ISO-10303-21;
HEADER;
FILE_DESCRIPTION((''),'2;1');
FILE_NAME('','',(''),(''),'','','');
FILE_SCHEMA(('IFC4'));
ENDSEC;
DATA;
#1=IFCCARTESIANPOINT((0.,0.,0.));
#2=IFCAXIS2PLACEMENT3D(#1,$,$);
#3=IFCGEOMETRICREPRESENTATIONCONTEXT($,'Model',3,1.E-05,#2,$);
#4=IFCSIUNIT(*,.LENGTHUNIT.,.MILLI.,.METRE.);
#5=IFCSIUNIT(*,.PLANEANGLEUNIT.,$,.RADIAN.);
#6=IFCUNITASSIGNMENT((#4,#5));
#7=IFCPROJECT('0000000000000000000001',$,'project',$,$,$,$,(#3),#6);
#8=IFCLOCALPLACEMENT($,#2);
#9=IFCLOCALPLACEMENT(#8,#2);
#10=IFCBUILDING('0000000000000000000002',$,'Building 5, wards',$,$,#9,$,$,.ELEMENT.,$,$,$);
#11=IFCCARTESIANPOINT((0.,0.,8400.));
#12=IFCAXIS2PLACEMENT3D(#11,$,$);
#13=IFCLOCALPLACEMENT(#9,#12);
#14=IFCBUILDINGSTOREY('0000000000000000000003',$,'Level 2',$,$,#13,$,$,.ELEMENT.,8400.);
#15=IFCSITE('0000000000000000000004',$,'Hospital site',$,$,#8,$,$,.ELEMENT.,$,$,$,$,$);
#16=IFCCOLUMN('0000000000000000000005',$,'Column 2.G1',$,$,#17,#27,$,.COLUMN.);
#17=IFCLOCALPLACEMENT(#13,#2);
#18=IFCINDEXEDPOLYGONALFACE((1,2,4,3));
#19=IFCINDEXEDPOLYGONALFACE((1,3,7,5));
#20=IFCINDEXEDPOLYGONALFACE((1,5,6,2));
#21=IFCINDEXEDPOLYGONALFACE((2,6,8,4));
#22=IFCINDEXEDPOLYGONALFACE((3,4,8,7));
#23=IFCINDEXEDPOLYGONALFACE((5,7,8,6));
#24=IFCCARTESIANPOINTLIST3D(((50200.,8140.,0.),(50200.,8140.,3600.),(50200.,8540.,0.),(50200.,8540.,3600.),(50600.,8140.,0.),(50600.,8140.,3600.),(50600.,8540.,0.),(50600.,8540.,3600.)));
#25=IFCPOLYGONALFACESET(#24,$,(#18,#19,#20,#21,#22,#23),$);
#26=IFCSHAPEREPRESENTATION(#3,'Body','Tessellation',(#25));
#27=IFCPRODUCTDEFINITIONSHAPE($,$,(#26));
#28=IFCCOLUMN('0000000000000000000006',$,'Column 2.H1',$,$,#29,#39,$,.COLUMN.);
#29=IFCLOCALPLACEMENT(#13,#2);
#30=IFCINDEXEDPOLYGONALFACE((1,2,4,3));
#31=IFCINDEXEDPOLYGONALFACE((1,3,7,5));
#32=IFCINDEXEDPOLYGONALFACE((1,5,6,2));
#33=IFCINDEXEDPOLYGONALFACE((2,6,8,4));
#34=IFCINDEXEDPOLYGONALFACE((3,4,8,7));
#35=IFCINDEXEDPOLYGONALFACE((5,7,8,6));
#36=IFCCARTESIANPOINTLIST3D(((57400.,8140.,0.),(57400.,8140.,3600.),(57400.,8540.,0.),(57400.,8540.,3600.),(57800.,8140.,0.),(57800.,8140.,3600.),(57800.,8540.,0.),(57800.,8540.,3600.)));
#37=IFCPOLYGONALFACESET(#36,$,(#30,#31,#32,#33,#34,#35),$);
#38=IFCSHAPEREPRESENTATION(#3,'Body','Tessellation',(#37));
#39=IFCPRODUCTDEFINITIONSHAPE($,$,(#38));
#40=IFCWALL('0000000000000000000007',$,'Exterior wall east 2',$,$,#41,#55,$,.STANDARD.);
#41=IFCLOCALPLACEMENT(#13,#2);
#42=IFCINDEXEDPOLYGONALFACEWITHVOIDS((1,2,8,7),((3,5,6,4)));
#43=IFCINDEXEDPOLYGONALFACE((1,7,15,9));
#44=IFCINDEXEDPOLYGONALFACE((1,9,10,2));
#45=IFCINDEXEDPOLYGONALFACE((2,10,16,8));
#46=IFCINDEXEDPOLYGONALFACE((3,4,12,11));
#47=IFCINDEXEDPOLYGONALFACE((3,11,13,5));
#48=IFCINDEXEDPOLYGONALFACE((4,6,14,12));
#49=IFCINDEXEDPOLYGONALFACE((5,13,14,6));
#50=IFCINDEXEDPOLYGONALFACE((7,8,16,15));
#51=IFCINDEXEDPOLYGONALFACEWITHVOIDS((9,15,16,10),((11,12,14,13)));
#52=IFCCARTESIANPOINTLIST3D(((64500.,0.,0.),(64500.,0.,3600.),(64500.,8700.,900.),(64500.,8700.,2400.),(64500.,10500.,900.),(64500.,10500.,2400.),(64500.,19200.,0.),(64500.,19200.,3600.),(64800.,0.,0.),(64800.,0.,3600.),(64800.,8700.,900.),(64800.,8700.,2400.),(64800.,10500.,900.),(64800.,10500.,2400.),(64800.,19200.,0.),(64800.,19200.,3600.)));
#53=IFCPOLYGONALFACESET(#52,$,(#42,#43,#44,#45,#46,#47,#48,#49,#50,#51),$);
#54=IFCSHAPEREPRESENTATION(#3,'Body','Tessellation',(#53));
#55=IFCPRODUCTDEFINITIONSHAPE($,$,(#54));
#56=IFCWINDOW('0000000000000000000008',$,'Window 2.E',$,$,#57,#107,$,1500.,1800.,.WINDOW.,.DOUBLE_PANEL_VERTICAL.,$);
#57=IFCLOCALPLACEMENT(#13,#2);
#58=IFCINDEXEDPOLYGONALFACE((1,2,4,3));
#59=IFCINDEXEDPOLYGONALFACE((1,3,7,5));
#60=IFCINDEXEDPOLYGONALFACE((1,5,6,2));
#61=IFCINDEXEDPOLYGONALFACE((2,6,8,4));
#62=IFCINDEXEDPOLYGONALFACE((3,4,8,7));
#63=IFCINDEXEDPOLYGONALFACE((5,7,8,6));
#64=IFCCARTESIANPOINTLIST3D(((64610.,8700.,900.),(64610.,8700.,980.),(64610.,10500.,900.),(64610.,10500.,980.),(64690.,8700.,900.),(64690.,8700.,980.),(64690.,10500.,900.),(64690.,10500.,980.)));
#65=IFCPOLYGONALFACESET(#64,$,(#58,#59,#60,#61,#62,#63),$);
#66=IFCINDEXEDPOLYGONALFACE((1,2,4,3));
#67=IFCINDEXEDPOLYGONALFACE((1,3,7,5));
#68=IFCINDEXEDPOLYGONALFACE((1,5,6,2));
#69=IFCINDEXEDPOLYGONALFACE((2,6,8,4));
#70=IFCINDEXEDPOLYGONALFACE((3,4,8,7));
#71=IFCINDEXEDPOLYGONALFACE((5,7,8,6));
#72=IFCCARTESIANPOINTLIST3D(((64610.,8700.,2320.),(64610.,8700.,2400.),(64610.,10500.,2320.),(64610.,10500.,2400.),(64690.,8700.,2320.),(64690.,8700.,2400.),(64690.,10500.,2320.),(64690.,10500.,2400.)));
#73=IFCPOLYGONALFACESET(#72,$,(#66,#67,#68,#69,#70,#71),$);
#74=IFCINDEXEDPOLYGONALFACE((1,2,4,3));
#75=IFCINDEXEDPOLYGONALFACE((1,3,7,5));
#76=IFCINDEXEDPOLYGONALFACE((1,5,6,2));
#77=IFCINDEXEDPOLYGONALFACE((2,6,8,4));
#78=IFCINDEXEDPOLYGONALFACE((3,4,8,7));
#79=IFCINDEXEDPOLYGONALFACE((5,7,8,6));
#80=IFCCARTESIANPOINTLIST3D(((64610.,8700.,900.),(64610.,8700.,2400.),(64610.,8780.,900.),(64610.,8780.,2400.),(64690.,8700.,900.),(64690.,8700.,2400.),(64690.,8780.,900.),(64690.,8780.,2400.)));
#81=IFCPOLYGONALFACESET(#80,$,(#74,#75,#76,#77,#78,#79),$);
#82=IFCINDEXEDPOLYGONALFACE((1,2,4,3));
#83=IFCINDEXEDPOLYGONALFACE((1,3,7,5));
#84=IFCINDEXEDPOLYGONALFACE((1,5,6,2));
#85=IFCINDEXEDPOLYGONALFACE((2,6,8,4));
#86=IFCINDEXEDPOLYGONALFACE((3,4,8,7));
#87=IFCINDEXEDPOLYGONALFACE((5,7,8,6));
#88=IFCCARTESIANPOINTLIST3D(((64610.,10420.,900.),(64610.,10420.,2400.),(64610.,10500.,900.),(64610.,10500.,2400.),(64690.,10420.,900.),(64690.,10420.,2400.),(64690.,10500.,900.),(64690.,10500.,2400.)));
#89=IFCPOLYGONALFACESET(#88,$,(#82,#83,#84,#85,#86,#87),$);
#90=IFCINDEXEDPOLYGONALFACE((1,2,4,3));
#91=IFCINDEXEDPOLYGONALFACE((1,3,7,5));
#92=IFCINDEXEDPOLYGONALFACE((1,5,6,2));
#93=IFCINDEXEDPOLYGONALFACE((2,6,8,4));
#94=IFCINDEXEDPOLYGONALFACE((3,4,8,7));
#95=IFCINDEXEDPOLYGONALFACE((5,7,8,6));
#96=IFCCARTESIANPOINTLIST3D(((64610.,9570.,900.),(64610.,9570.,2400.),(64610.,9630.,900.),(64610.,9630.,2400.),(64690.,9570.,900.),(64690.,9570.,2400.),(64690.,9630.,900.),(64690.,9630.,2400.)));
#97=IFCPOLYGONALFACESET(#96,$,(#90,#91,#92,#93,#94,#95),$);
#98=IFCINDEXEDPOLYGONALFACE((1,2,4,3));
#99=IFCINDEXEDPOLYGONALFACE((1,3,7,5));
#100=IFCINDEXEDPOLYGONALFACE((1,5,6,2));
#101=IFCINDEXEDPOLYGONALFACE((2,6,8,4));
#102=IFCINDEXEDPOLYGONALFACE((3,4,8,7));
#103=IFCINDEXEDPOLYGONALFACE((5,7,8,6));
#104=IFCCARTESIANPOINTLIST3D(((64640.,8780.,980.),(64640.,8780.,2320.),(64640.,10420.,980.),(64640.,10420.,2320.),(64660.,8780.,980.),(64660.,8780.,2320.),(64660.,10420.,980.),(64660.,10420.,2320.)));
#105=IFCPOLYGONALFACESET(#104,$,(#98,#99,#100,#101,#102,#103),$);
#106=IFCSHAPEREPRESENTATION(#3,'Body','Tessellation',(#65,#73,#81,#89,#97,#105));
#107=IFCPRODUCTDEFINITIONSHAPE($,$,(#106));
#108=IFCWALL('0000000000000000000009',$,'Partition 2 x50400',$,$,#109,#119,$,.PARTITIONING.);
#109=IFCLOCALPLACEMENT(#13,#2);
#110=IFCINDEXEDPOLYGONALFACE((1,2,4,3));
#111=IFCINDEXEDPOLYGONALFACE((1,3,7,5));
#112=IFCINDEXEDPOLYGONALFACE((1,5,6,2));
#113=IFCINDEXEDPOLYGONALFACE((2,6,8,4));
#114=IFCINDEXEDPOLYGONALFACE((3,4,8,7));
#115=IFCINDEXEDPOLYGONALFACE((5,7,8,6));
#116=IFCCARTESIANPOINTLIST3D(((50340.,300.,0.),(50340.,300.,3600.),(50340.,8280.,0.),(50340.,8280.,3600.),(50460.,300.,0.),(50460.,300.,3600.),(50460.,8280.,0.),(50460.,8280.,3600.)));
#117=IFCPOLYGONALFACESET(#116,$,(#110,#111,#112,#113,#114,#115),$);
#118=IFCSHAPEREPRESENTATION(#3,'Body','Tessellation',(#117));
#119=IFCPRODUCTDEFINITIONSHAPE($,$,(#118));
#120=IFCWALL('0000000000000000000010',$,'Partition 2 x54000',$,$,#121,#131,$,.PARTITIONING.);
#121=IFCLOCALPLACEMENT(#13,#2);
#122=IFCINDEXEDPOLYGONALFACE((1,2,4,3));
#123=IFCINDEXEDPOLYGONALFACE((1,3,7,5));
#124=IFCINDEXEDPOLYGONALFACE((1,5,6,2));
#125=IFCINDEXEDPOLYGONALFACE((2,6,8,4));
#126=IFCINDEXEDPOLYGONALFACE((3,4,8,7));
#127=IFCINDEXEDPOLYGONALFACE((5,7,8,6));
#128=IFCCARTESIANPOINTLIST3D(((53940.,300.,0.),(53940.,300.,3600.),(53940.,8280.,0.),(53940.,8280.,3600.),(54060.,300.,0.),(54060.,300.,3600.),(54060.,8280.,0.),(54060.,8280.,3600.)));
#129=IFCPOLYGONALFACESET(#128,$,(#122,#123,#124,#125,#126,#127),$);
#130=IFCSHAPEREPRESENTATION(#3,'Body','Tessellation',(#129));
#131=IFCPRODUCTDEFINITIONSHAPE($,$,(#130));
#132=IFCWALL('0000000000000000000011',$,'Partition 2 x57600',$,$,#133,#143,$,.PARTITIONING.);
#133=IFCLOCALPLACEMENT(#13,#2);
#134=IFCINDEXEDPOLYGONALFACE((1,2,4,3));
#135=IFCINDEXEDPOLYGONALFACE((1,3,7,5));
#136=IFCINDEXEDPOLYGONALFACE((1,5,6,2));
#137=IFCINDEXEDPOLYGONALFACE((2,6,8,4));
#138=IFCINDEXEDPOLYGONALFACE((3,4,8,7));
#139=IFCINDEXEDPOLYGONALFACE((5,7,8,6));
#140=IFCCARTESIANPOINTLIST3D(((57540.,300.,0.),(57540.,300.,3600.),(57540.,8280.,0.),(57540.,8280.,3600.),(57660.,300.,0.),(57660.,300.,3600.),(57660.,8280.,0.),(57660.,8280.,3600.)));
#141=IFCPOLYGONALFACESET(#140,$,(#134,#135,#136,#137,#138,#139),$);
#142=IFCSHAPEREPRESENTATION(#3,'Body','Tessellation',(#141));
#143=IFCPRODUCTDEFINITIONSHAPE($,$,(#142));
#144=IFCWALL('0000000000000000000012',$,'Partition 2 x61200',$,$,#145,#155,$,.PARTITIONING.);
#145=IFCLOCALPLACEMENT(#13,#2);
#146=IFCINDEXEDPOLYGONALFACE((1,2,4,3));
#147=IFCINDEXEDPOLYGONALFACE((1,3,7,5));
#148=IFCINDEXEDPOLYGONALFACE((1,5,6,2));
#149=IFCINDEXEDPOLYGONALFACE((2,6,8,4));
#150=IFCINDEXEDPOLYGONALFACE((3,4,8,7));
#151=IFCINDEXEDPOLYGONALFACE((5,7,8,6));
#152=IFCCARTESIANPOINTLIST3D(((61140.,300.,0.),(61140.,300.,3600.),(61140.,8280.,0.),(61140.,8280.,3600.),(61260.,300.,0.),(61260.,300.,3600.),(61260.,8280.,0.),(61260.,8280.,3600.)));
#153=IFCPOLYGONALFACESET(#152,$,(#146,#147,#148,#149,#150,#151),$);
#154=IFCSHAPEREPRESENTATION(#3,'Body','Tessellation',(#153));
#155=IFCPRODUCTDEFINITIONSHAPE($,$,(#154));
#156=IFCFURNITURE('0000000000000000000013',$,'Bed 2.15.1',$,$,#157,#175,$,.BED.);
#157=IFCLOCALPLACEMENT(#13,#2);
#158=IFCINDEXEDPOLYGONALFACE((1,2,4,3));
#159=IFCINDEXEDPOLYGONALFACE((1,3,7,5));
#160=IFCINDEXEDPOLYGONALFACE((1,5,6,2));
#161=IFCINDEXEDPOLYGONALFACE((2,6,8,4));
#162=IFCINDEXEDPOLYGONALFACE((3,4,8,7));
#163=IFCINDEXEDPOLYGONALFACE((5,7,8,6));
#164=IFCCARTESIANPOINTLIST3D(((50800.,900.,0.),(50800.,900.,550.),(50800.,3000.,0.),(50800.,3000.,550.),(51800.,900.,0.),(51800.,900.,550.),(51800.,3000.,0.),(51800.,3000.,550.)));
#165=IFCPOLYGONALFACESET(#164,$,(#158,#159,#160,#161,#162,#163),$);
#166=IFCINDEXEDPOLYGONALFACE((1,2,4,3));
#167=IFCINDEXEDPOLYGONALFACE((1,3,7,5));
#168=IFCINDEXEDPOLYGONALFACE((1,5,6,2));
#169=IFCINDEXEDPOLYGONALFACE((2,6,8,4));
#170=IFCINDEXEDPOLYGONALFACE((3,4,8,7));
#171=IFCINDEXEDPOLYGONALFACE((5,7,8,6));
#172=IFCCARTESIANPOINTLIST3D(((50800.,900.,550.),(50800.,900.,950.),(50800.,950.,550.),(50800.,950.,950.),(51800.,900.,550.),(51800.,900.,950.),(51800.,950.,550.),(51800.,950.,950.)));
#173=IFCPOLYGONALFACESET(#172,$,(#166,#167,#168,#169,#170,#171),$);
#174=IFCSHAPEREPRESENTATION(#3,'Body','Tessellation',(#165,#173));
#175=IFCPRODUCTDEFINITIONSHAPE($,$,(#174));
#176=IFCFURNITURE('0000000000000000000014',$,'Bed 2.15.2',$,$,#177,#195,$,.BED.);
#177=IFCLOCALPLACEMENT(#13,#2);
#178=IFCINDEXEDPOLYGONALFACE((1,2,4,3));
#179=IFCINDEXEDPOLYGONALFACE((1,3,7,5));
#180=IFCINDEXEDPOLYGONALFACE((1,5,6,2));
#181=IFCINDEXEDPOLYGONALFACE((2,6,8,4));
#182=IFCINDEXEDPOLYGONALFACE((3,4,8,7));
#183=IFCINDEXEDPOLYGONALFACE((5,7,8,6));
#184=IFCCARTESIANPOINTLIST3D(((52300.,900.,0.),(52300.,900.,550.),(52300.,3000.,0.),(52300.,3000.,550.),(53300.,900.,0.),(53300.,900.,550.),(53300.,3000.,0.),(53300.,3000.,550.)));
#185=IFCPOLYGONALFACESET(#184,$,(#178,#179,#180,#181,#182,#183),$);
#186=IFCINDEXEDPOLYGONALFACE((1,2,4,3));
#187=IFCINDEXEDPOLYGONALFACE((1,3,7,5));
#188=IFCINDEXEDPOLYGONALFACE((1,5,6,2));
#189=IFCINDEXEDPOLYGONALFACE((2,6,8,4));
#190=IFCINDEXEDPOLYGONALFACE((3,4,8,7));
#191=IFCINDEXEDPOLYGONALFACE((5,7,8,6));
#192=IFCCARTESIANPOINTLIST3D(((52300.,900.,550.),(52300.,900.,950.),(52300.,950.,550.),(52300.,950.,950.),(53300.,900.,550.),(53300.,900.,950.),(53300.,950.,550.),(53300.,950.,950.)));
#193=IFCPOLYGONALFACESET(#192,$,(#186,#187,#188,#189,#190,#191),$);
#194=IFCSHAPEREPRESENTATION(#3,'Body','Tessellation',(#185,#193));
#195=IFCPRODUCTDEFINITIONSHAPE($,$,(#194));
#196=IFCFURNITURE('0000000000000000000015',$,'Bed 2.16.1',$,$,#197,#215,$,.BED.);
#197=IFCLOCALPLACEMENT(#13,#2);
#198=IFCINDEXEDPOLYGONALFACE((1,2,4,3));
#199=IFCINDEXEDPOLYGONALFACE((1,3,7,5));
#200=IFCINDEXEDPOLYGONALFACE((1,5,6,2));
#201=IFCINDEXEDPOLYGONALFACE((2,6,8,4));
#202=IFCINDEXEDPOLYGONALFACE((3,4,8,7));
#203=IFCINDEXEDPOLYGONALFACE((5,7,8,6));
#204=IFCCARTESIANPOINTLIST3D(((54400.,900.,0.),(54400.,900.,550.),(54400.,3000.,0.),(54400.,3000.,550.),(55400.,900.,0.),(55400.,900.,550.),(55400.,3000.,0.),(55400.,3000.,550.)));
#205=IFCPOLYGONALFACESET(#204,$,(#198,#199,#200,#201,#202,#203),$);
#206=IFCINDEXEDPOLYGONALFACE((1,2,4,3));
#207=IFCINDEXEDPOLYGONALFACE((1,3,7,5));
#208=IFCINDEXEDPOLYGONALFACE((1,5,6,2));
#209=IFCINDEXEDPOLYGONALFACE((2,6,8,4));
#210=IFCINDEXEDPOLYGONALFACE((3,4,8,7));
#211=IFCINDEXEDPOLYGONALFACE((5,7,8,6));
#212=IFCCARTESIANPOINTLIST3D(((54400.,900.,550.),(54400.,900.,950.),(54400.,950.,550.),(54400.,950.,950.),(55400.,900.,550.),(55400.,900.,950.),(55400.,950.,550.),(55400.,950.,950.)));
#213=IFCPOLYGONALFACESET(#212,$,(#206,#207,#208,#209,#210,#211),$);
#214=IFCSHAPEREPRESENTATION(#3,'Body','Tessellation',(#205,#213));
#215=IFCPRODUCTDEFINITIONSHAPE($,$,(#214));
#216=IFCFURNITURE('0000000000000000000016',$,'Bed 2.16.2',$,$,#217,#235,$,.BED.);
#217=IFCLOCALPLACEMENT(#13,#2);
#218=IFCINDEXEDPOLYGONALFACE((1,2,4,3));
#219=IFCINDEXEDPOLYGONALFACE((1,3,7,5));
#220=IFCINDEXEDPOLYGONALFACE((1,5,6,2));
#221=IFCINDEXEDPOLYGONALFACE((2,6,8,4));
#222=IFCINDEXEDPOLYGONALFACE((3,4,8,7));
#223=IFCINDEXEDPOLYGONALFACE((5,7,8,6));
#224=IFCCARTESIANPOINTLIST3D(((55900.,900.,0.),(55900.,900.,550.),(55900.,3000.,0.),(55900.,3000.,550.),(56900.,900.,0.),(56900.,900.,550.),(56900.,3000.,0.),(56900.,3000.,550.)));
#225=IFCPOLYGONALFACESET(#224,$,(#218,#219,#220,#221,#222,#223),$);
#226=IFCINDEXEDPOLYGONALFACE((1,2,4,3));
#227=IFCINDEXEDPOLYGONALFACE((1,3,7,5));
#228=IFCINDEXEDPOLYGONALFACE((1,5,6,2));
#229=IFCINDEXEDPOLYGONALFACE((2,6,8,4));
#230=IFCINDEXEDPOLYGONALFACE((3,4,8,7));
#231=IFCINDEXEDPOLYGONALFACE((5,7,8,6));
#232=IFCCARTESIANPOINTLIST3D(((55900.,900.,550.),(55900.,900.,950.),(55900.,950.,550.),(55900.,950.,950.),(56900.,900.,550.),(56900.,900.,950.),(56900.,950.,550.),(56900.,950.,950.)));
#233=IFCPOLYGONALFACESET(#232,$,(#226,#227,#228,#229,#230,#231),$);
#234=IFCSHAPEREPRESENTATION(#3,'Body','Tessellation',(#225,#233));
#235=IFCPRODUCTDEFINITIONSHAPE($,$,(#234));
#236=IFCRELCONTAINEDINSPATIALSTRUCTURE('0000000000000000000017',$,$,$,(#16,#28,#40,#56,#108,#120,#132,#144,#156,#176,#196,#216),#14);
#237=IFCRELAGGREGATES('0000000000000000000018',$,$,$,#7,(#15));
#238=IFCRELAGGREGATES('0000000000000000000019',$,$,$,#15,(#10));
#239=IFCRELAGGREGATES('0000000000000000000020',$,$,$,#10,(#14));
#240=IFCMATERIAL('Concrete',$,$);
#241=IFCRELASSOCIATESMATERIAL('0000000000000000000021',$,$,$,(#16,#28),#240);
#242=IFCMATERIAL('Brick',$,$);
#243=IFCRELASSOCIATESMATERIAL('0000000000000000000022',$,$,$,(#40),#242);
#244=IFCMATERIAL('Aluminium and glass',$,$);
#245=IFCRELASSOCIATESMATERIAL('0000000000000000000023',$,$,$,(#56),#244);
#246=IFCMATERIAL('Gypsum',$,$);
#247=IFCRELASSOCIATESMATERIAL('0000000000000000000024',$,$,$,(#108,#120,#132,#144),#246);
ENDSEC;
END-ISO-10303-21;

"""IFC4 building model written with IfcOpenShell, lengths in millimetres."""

from ifc_helpers import new_model, si_unit, frame, frame_2d, origin, origin_2d, place, context, project, spatial, rectangle, extrude, material, element, fill, save


model = new_model("IFC4")

# Units and contexts
model_context = context("Model", 3, precision=1e-05, world=origin())
ifc_project = project(units=[si_unit("LENGTHUNIT", "METRE", prefix="MILLI"), si_unit("PLANEANGLEUNIT", "RADIAN")], contexts=[model_context])

# Site, building, storey
site_placement = place(None, origin())
site = spatial("IfcSite", under=ifc_project, at=site_placement, Name="Hospital site", CompositionType="ELEMENT")
building_placement = place(site_placement, origin())
building = spatial("IfcBuilding", under=site, at=building_placement, Name="Building 5, wards", CompositionType="ELEMENT")
storey_placement = place(building_placement, frame((0.0, 0.0, 8400.0)))
storey = spatial("IfcBuildingStorey", under=building, at=storey_placement, Name="Level 2", CompositionType="ELEMENT", Elevation=8400.0)

# Columns
ifc_material_1 = material(Name="Concrete")
for number, where, name in (
    (1, (50400.0, 8340.0, 0.0), "Column 2.G1"),
    (2, (57600.0, 8340.0, 0.0), "Column 2.H1"),
):
    element("IfcColumn", number, at=place(storey_placement, frame(where)), inside=storey, material=ifc_material_1, Name=name, PredefinedType="COLUMN", context=model_context, shape_type="SweptSolid", body=[
        extrude(rectangle(XDim=400.0, YDim=400.0, at=origin_2d()), origin(), (0.0, 0.0, 1.0), 3600.0),
    ])

# Wall, opening, window
ifc_material_2 = material(Name="Brick")
wall_placement = place(storey_placement, frame((64800.0, 0.0, 0.0), x_axis=(0.0, 1.0, 0.0)))
wall = element("IfcWall", 3, at=wall_placement, inside=storey, material=ifc_material_2, Name="Exterior wall east 2", PredefinedType="STANDARD", context=model_context, shape_type="SweptSolid", body=[
    extrude(rectangle(XDim=19200.0, YDim=300.0, at=frame_2d((9600.0, 150.0))), origin(), (0.0, 0.0, 1.0), 3600.0),
])
opening_placement = place(wall_placement, frame((8700.0, -50.0, 900.0)))
opening = element("IfcOpeningElement", 4, at=opening_placement, cuts=wall, PredefinedType="OPENING", context=model_context, shape_type="SweptSolid", body=[
    extrude(rectangle(XDim=1800.0, YDim=400.0, at=frame_2d((900.0, 200.0))), origin(), (0.0, 0.0, 1.0), 1500.0),
])
ifc_material_3 = material(Name="Aluminium and glass")
window_placement = place(opening_placement, frame((0.0, 160.0, 0.0)))
window = element("IfcWindow", 5, at=window_placement, inside=storey, material=ifc_material_3, Name="Window 2.E", OverallHeight=1500.0, OverallWidth=1800.0, PartitioningType="DOUBLE_PANEL_VERTICAL", PredefinedType="WINDOW", context=model_context, shape_type="SweptSolid", body=[
    extrude(rectangle(XDim=1800.0, YDim=80.0, at=frame_2d((900.0, 40.0))), origin(), (0.0, 0.0, 1.0), 80.0),
    extrude(rectangle(XDim=1800.0, YDim=80.0, at=frame_2d((900.0, 40.0))), frame((0.0, 0.0, 1420.0)), (0.0, 0.0, 1.0), 80.0),
    extrude(rectangle(XDim=80.0, YDim=80.0, at=frame_2d((40.0, 40.0))), origin(), (0.0, 0.0, 1.0), 1500.0),
    extrude(rectangle(XDim=80.0, YDim=80.0, at=frame_2d((1760.0, 40.0))), origin(), (0.0, 0.0, 1.0), 1500.0),
    extrude(rectangle(XDim=60.0, YDim=80.0, at=frame_2d((900.0, 40.0))), origin(), (0.0, 0.0, 1.0), 1500.0),
    extrude(rectangle(XDim=1640.0, YDim=20.0, at=frame_2d((900.0, 40.0))), frame((0.0, 0.0, 80.0)), (0.0, 0.0, 1.0), 1340.0),
])
fill(opening, window)

# Walls
ifc_material_4 = material(Name="Gypsum")
for number, where, x_axis, name in (
    (6, (50460.0, 300.0, 0.0), (0.0, 1.0, 0.0), "Partition 2 x50400"),
    (7, (54060.0, 300.0, 0.0), (0.0, 1.0, 0.0), "Partition 2 x54000"),
    (8, (57660.0, 300.0, 0.0), (0.0, 1.0, 0.0), "Partition 2 x57600"),
    (9, (61260.0, 300.0, 0.0), (0.0, 1.0, 0.0), "Partition 2 x61200"),
):
    element("IfcWall", number, at=place(storey_placement, frame(where, x_axis=x_axis)), inside=storey, material=ifc_material_4, Name=name, PredefinedType="PARTITIONING", context=model_context, shape_type="SweptSolid", body=[
        extrude(rectangle(XDim=7980.0, YDim=120.0, at=frame_2d((3990.0, 60.0))), origin(), (0.0, 0.0, 1.0), 3600.0),
    ])

# Furniture
for number, where, name in (
    (10, (50800.0, 900.0, 0.0), "Bed 2.15.1"),
    (11, (52300.0, 900.0, 0.0), "Bed 2.15.2"),
    (12, (54400.0, 900.0, 0.0), "Bed 2.16.1"),
    (13, (55900.0, 900.0, 0.0), "Bed 2.16.2"),
):
    element("IfcFurniture", number, at=place(storey_placement, frame(where)), inside=storey, Name=name, PredefinedType="BED", context=model_context, shape_type="SweptSolid", body=[
        extrude(rectangle(XDim=1000.0, YDim=2100.0, at=frame_2d((500.0, 1050.0))), origin(), (0.0, 0.0, 1.0), 550.0),
        extrude(rectangle(XDim=1000.0, YDim=50.0, at=frame_2d((500.0, 25.0))), frame((0.0, 0.0, 550.0)), (0.0, 0.0, 1.0), 400.0),
    ])

save(model, "model.ifc")
